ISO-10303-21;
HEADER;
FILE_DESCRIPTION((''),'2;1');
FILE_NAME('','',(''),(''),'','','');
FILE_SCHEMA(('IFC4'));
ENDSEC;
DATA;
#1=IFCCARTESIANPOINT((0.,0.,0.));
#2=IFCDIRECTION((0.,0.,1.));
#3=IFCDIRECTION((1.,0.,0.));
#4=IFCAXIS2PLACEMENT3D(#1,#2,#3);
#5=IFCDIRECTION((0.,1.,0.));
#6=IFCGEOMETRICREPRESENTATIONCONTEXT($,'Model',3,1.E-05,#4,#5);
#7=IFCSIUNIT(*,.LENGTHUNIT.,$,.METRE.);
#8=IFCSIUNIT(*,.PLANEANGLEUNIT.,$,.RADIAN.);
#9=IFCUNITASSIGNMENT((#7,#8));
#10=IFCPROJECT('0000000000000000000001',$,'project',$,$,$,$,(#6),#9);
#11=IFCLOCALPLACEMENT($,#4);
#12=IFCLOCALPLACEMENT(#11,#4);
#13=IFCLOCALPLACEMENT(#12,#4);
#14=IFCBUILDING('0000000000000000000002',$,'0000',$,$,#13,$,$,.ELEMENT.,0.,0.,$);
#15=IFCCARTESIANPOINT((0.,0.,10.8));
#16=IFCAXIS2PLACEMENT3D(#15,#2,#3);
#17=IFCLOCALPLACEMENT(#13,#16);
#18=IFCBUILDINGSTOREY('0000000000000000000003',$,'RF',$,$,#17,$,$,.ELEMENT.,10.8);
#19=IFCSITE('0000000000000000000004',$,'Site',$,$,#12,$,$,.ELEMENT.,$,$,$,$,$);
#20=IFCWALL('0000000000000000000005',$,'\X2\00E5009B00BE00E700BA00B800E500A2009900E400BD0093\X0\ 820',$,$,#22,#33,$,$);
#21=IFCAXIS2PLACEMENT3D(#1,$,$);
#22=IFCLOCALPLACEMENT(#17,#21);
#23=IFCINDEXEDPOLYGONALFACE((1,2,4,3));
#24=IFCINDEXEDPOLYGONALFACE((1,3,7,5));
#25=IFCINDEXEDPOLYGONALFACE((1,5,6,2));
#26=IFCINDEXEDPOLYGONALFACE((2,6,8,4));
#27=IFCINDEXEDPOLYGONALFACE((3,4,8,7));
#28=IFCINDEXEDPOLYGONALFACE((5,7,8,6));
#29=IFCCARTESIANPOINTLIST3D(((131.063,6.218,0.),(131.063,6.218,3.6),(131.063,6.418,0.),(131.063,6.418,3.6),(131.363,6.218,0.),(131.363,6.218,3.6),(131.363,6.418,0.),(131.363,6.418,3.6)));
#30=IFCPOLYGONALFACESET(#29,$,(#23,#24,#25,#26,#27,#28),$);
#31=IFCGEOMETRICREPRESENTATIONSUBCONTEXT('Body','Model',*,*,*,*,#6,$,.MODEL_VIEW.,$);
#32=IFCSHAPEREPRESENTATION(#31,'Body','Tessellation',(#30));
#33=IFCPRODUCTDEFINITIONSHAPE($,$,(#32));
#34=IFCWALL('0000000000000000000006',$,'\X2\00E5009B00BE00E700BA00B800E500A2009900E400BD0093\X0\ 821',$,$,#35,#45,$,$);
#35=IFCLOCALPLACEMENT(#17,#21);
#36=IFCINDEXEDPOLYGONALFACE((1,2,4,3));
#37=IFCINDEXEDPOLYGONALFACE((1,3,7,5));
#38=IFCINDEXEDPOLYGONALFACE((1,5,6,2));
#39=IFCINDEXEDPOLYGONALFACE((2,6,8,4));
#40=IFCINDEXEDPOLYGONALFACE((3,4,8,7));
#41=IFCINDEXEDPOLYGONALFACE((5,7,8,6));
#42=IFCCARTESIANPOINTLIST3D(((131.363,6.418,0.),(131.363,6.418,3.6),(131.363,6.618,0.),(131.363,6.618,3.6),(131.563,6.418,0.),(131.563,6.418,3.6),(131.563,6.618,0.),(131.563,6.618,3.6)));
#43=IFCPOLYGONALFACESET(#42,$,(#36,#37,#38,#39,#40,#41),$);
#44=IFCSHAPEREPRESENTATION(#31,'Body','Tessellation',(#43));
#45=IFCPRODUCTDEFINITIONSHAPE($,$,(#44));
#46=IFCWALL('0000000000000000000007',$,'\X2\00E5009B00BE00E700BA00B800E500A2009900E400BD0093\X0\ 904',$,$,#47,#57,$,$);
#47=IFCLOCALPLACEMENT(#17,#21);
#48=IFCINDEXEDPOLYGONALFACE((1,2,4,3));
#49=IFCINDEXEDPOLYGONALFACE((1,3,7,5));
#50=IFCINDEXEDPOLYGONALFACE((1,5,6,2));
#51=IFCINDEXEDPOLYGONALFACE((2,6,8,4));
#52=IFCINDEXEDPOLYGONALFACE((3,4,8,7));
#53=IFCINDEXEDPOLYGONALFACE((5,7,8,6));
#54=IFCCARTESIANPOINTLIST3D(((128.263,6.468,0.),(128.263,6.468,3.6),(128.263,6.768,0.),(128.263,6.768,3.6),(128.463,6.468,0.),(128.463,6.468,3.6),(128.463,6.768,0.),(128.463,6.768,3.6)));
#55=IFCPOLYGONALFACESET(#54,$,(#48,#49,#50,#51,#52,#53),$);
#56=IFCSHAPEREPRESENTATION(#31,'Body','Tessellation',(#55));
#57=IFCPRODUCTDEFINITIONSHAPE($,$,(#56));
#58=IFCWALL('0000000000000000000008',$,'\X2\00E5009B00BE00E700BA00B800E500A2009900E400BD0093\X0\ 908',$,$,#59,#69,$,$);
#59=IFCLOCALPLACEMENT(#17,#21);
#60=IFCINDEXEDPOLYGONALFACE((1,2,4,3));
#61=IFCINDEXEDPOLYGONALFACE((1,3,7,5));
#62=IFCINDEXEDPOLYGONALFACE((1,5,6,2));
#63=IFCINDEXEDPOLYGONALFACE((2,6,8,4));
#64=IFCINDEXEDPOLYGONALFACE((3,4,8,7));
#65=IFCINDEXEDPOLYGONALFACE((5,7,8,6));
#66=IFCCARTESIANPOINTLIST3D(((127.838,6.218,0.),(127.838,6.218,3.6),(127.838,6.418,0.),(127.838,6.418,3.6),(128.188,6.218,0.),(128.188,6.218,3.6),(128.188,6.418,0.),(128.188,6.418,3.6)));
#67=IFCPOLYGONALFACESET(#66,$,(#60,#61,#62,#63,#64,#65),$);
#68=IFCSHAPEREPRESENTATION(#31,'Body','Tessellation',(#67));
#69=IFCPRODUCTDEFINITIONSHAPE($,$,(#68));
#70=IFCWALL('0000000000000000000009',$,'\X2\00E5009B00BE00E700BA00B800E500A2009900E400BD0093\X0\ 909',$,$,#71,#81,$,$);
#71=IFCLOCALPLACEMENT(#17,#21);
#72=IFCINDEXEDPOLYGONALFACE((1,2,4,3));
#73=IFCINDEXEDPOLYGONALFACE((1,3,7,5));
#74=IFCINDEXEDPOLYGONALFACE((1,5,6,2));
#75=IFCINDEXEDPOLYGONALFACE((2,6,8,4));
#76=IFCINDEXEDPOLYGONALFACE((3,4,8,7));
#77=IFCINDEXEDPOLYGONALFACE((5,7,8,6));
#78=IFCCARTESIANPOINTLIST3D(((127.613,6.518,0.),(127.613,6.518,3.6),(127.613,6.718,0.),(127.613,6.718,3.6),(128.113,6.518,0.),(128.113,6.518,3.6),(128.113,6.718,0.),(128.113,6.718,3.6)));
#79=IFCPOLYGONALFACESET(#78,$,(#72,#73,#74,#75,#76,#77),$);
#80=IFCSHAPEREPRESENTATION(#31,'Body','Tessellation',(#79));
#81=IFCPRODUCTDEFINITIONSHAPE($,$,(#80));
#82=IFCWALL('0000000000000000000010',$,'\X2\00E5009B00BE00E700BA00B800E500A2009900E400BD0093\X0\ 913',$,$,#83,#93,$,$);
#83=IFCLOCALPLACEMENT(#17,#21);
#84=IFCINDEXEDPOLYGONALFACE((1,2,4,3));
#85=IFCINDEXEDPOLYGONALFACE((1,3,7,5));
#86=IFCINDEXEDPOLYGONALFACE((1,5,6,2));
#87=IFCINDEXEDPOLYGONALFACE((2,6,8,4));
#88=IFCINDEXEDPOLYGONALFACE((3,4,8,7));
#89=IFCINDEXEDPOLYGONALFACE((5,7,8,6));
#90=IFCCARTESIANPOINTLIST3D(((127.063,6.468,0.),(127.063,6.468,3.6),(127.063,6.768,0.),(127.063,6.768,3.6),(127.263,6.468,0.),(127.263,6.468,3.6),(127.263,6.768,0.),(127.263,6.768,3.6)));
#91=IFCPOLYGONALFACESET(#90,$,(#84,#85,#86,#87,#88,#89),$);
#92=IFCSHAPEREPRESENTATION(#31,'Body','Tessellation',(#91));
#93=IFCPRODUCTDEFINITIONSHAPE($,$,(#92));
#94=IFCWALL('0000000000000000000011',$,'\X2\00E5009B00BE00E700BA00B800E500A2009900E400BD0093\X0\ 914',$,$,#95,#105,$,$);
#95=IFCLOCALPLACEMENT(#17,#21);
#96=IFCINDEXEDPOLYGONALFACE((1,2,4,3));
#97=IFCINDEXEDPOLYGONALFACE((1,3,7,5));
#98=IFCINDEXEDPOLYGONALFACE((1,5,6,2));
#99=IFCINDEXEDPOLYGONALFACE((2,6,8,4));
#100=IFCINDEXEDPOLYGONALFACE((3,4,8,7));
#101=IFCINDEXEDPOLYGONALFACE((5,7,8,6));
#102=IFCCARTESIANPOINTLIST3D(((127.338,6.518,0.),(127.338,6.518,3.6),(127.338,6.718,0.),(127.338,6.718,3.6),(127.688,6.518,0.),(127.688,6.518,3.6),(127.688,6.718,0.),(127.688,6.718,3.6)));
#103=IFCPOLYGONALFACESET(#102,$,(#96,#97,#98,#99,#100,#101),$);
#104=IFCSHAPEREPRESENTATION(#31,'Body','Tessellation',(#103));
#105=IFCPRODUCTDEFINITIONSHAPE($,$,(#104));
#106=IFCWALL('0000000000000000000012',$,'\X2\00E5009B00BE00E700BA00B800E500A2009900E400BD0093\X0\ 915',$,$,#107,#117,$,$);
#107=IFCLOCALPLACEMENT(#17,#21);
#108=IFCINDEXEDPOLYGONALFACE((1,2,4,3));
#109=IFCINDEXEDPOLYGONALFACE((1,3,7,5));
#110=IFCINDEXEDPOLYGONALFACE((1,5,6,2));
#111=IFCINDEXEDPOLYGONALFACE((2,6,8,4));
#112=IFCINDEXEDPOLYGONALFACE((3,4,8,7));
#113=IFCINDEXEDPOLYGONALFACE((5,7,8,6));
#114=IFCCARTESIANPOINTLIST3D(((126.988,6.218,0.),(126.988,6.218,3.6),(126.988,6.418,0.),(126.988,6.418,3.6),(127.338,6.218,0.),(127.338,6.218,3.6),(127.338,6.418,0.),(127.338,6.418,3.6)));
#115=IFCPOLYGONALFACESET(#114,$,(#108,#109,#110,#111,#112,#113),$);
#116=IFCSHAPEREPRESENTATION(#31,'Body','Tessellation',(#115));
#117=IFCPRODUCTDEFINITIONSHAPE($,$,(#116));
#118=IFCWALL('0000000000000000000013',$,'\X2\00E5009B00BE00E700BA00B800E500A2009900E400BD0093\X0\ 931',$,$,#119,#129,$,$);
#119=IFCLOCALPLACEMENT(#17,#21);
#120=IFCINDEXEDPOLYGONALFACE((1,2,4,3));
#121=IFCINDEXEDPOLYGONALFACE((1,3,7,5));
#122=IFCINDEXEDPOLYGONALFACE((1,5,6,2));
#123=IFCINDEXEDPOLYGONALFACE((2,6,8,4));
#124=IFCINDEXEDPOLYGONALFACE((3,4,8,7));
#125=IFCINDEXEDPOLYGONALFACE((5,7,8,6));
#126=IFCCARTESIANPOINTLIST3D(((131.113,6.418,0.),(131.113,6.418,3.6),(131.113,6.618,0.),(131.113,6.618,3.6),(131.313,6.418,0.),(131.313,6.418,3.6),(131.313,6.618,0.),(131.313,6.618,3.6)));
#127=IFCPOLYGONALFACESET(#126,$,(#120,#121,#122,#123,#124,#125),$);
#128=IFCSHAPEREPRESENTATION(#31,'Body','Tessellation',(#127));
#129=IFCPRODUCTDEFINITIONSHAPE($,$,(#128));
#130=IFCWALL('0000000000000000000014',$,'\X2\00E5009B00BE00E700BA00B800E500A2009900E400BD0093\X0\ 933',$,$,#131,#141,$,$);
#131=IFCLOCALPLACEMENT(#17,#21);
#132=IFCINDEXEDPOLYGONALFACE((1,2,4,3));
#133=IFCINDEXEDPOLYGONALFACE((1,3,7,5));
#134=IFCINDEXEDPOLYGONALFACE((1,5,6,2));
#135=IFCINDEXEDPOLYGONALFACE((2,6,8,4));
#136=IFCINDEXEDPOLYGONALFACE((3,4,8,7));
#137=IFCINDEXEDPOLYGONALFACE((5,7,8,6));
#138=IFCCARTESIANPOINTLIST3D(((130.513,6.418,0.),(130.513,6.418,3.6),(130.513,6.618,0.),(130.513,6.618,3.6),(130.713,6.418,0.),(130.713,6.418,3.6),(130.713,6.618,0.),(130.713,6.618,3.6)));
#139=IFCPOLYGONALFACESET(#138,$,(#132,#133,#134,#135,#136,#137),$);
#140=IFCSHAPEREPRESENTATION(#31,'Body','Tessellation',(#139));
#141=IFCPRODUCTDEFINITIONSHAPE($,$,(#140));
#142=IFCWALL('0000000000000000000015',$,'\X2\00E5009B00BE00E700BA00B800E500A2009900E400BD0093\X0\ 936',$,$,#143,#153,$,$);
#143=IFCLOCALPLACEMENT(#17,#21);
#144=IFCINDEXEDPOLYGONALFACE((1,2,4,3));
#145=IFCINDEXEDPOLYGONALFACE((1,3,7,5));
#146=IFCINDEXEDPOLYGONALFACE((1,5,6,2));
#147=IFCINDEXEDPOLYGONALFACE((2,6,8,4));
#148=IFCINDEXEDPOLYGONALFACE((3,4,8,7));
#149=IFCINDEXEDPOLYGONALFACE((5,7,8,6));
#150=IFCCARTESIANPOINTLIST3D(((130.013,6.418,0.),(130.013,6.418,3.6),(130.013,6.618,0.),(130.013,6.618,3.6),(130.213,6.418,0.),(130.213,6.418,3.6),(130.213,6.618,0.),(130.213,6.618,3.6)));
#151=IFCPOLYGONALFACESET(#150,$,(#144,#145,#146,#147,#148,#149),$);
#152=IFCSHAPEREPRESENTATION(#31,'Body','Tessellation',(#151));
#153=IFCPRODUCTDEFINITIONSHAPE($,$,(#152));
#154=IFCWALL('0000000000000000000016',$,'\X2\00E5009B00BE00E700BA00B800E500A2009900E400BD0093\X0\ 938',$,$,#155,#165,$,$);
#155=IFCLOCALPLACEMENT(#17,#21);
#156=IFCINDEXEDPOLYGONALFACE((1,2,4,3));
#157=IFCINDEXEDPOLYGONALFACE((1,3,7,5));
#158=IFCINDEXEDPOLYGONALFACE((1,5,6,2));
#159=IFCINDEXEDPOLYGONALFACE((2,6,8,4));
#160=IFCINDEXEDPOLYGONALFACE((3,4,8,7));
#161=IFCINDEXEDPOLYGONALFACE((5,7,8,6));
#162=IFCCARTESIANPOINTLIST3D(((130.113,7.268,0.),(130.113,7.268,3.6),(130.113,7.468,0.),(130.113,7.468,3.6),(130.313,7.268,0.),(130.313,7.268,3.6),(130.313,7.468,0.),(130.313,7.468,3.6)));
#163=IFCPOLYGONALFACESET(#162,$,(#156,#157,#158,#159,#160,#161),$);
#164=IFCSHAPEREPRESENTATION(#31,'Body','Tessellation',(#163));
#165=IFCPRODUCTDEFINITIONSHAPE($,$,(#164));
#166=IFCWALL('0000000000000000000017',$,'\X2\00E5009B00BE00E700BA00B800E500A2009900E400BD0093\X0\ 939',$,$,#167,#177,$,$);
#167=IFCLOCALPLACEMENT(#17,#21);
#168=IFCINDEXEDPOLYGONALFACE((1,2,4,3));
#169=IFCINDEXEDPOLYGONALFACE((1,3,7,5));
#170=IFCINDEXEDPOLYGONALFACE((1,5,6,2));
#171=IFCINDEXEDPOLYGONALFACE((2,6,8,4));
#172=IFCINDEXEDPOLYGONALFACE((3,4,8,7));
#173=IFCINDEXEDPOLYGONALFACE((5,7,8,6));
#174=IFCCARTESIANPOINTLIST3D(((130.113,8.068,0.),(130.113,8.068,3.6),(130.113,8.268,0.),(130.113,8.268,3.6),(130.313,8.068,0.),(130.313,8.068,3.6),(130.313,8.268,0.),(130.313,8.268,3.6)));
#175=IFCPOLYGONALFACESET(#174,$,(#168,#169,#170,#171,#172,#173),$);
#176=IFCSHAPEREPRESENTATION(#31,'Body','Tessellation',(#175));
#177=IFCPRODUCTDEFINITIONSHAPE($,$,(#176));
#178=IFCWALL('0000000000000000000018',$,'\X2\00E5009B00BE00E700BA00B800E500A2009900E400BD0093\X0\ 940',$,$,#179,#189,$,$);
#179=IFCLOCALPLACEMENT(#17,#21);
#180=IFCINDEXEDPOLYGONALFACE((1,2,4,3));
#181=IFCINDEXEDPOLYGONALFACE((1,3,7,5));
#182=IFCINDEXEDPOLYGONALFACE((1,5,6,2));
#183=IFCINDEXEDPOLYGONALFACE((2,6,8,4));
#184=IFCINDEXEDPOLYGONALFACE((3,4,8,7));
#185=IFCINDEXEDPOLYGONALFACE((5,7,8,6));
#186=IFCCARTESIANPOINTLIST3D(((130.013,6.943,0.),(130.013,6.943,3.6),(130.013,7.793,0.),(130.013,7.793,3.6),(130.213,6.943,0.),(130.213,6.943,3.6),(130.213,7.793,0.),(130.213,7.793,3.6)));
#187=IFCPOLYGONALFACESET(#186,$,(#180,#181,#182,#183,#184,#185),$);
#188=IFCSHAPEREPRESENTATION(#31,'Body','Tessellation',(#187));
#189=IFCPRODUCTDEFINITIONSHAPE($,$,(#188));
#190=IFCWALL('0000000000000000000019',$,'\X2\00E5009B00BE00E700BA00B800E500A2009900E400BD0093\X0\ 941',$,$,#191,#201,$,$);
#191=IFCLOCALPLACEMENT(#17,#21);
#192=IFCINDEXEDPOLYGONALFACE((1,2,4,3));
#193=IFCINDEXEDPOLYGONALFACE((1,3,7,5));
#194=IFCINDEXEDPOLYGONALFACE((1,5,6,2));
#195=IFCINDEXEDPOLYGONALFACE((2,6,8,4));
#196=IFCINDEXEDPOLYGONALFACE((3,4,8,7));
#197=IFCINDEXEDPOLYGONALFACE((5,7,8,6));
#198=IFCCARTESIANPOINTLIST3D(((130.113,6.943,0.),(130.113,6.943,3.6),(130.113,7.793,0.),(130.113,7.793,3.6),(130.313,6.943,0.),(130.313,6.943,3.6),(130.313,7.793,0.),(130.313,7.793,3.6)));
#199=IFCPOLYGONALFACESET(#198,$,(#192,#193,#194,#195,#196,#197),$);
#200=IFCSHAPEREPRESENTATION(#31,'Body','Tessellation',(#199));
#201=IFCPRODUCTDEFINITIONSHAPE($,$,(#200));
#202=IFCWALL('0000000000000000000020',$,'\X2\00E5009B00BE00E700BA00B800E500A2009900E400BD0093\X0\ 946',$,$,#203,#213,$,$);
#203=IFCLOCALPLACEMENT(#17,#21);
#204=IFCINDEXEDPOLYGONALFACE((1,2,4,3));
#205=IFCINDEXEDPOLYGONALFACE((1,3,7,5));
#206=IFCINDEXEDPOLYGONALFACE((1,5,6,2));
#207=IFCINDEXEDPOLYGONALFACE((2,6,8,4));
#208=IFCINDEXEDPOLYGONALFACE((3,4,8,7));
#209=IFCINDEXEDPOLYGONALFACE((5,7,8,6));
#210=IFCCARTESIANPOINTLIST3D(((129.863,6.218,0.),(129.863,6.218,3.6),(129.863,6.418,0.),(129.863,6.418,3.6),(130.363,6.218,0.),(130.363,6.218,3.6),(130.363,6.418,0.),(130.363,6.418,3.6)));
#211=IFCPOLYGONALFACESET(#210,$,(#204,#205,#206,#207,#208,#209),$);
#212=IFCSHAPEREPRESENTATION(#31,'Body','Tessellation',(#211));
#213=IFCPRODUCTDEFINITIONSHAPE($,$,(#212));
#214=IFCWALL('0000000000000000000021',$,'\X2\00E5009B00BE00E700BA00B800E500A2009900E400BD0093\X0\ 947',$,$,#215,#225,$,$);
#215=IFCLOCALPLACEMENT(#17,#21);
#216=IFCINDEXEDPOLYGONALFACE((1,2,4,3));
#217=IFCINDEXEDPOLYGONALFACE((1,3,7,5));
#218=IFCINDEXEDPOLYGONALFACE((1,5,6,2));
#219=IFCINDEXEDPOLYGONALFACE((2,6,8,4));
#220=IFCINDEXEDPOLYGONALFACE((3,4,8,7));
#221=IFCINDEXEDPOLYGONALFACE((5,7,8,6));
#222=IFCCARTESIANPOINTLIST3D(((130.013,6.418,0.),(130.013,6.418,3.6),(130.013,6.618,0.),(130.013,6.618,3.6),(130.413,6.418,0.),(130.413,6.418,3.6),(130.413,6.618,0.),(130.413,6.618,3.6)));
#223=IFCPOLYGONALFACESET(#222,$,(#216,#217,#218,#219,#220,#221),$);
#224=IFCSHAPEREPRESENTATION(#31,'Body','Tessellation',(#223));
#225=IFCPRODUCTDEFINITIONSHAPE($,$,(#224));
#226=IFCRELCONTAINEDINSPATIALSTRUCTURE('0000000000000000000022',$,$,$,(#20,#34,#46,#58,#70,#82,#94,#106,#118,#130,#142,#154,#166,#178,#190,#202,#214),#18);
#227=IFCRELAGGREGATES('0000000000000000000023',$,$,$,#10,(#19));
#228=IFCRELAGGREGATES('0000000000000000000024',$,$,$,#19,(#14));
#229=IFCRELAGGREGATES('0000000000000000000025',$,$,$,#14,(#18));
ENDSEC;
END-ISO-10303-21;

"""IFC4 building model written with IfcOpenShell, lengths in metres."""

from ifc_helpers import new_model, si_unit, direction, frame, frame_2d, origin_with_axes, place, context, subcontext, project, spatial, rectangle, extrude, element, save


model = new_model("IFC4")

# Units and contexts
model_context = context("Model", 3, precision=1e-05, world=origin_with_axes(), true_north=direction((0.0, 1.0, 0.0)))
body_context = subcontext(model_context, "Body", "Model", "MODEL_VIEW")
ifc_project = project(units=[si_unit("LENGTHUNIT", "METRE"), si_unit("PLANEANGLEUNIT", "RADIAN")], contexts=[model_context])

# Site, building, storey
placement = place(None, origin_with_axes())
site_placement = place(placement, origin_with_axes())
site = spatial("IfcSite", under=ifc_project, at=site_placement, Name="Site", CompositionType="ELEMENT")
building_placement = place(site_placement, origin_with_axes())
building = spatial("IfcBuilding", under=site, at=building_placement, Name="0000", CompositionType="ELEMENT", ElevationOfRefHeight=0.0, ElevationOfTerrain=0.0)
storey_placement = place(building_placement, frame((0.0, 0.0, 10.8), z_axis=(0.0, 0.0, 1.0), x_axis=(1.0, 0.0, 0.0)))
storey = spatial("IfcBuildingStorey", under=building, at=storey_placement, Name="RF", CompositionType="ELEMENT", Elevation=10.8)

# Walls
wall_1_placement = place(storey_placement, frame((131.213, 6.318, 0.0), z_axis=(0.0, 0.0, 1.0), x_axis=(1.0, 0.0, 0.0)))
element("IfcWall", 1, at=wall_1_placement, inside=storey, Name="å\u009b¾çº¸å¢\u0099ä½\u0093 820", context=body_context, shape_type="SweptSolid", body=[
    extrude(rectangle(XDim=0.3, YDim=0.2, at=frame_2d((0.0, 0.0), x_axis=(1.0, 0.0, 0.0))), frame((0.0, 0.0, 0.0), z_axis=(0.0, 0.0, 1.0)), (0.0, 0.0, 1.0), 3.6),
])
wall_2_placement = place(storey_placement, frame((131.463, 6.518, 0.0), z_axis=(0.0, 0.0, 1.0), x_axis=(1.0, 0.0, 0.0)))
element("IfcWall", 2, at=wall_2_placement, inside=storey, Name="å\u009b¾çº¸å¢\u0099ä½\u0093 821", context=body_context, shape_type="SweptSolid", body=[
    extrude(rectangle(XDim=0.2, YDim=0.2, at=frame_2d((0.0, 0.0), x_axis=(1.0, 0.0, 0.0))), frame((0.0, 0.0, 0.0), z_axis=(0.0, 0.0, 1.0)), (0.0, 0.0, 1.0), 3.6),
])
wall_3_placement = place(storey_placement, frame((128.363, 6.618, 0.0), z_axis=(0.0, 0.0, 1.0), x_axis=(0.0, -1.0, 0.0)))
element("IfcWall", 3, at=wall_3_placement, inside=storey, Name="å\u009b¾çº¸å¢\u0099ä½\u0093 904", context=body_context, shape_type="SweptSolid", body=[
    extrude(rectangle(XDim=0.3, YDim=0.2, at=frame_2d((0.0, 0.0), x_axis=(1.0, 0.0, 0.0))), frame((0.0, 0.0, 0.0), z_axis=(0.0, 0.0, 1.0)), (0.0, 0.0, 1.0), 3.6),
])
wall_4_placement = place(storey_placement, frame((128.013, 6.318, 0.0), z_axis=(0.0, 0.0, 1.0), x_axis=(1.0, 0.0, 0.0)))
element("IfcWall", 4, at=wall_4_placement, inside=storey, Name="å\u009b¾çº¸å¢\u0099ä½\u0093 908", context=body_context, shape_type="SweptSolid", body=[
    extrude(rectangle(XDim=0.35, YDim=0.2, at=frame_2d((0.0, 0.0), x_axis=(1.0, 0.0, 0.0))), frame((0.0, 0.0, 0.0), z_axis=(0.0, 0.0, 1.0)), (0.0, 0.0, 1.0), 3.6),
])
wall_5_placement = place(storey_placement, frame((127.863, 6.618, 0.0), z_axis=(0.0, 0.0, 1.0), x_axis=(1.0, 0.0, 0.0)))
element("IfcWall", 5, at=wall_5_placement, inside=storey, Name="å\u009b¾çº¸å¢\u0099ä½\u0093 909", context=body_context, shape_type="SweptSolid", body=[
    extrude(rectangle(XDim=0.5, YDim=0.2, at=frame_2d((0.0, 0.0), x_axis=(1.0, 0.0, 0.0))), frame((0.0, 0.0, 0.0), z_axis=(0.0, 0.0, 1.0)), (0.0, 0.0, 1.0), 3.6),
])
wall_6_placement = place(storey_placement, frame((127.163, 6.618, 0.0), z_axis=(0.0, 0.0, 1.0), x_axis=(0.0, -1.0, 0.0)))
element("IfcWall", 6, at=wall_6_placement, inside=storey, Name="å\u009b¾çº¸å¢\u0099ä½\u0093 913", context=body_context, shape_type="SweptSolid", body=[
    extrude(rectangle(XDim=0.3, YDim=0.2, at=frame_2d((0.0, 0.0), x_axis=(1.0, 0.0, 0.0))), frame((0.0, 0.0, 0.0), z_axis=(0.0, 0.0, 1.0)), (0.0, 0.0, 1.0), 3.6),
])
for number, where, z_axis, x_axis, name in (
    (7, (127.513, 6.618, 0.0), (0.0, 0.0, 1.0), (-1.0, 0.0, 0.0), "å\u009b¾çº¸å¢\u0099ä½\u0093 914"),
    (8, (127.163, 6.318, 0.0), (0.0, 0.0, 1.0), (1.0, 0.0, 0.0), "å\u009b¾çº¸å¢\u0099ä½\u0093 915"),
):
    element("IfcWall", number, at=place(storey_placement, frame(where, z_axis=z_axis, x_axis=x_axis)), inside=storey, Name=name, context=body_context, shape_type="SweptSolid", body=[
        extrude(rectangle(XDim=0.35, YDim=0.2, at=frame_2d((0.0, 0.0), x_axis=(1.0, 0.0, 0.0))), frame((0.0, 0.0, 0.0), z_axis=(0.0, 0.0, 1.0)), (0.0, 0.0, 1.0), 3.6),
    ])
for number, where, z_axis, x_axis, name in (
    (9, (131.213, 6.518, 0.0), (0.0, 0.0, 1.0), (1.0, 0.0, 0.0), "å\u009b¾çº¸å¢\u0099ä½\u0093 931"),
    (10, (130.613, 6.518, 0.0), (0.0, 0.0, 1.0), (0.0, -1.0, 0.0), "å\u009b¾çº¸å¢\u0099ä½\u0093 933"),
    (11, (130.113, 6.518, 0.0), (0.0, 0.0, 1.0), (0.0, -1.0, 0.0), "å\u009b¾çº¸å¢\u0099ä½\u0093 936"),
    (12, (130.213, 7.368, 0.0), (0.0, 0.0, 1.0), (-1.0, 0.0, 0.0), "å\u009b¾çº¸å¢\u0099ä½\u0093 938"),
    (13, (130.213, 8.168, 0.0), (0.0, 0.0, 1.0), (-1.0, 0.0, 0.0), "å\u009b¾çº¸å¢\u0099ä½\u0093 939"),
):
    element("IfcWall", number, at=place(storey_placement, frame(where, z_axis=z_axis, x_axis=x_axis)), inside=storey, Name=name, context=body_context, shape_type="SweptSolid", body=[
        extrude(rectangle(XDim=0.2, YDim=0.2, at=frame_2d((0.0, 0.0), x_axis=(1.0, 0.0, 0.0))), frame((0.0, 0.0, 0.0), z_axis=(0.0, 0.0, 1.0)), (0.0, 0.0, 1.0), 3.6),
    ])
for number, where, z_axis, x_axis, name in (
    (14, (130.113, 7.368, 0.0), (0.0, 0.0, 1.0), (0.0, -1.0, 0.0), "å\u009b¾çº¸å¢\u0099ä½\u0093 940"),
    (15, (130.213, 7.368, 0.0), (0.0, 0.0, 1.0), (0.0, -1.0, 0.0), "å\u009b¾çº¸å¢\u0099ä½\u0093 941"),
):
    element("IfcWall", number, at=place(storey_placement, frame(where, z_axis=z_axis, x_axis=x_axis)), inside=storey, Name=name, context=body_context, shape_type="SweptSolid", body=[
        extrude(rectangle(XDim=0.85, YDim=0.2, at=frame_2d((0.0, 0.0), x_axis=(1.0, 0.0, 0.0))), frame((0.0, 0.0, 0.0), z_axis=(0.0, 0.0, 1.0)), (0.0, 0.0, 1.0), 3.6),
    ])
wall_7_placement = place(storey_placement, frame((130.113, 6.318, 0.0), z_axis=(0.0, 0.0, 1.0), x_axis=(1.0, 0.0, 0.0)))
element("IfcWall", 16, at=wall_7_placement, inside=storey, Name="å\u009b¾çº¸å¢\u0099ä½\u0093 946", context=body_context, shape_type="SweptSolid", body=[
    extrude(rectangle(XDim=0.5, YDim=0.2, at=frame_2d((0.0, 0.0), x_axis=(1.0, 0.0, 0.0))), frame((0.0, 0.0, 0.0), z_axis=(0.0, 0.0, 1.0)), (0.0, 0.0, 1.0), 3.6),
])
for number, where, z_axis, x_axis, name in (
    (17, (130.213, 6.518, 0.0), (0.0, 0.0, 1.0), (1.0, 0.0, 0.0), "å\u009b¾çº¸å¢\u0099ä½\u0093 947"),
):
    element("IfcWall", number, at=place(storey_placement, frame(where, z_axis=z_axis, x_axis=x_axis)), inside=storey, Name=name, context=body_context, shape_type="SweptSolid", body=[
        extrude(rectangle(XDim=0.4, YDim=0.2, at=frame_2d((0.0, 0.0), x_axis=(1.0, 0.0, 0.0))), frame((0.0, 0.0, 0.0), z_axis=(0.0, 0.0, 1.0)), (0.0, 0.0, 1.0), 3.6),
    ])

save(model, "model.ifc")
